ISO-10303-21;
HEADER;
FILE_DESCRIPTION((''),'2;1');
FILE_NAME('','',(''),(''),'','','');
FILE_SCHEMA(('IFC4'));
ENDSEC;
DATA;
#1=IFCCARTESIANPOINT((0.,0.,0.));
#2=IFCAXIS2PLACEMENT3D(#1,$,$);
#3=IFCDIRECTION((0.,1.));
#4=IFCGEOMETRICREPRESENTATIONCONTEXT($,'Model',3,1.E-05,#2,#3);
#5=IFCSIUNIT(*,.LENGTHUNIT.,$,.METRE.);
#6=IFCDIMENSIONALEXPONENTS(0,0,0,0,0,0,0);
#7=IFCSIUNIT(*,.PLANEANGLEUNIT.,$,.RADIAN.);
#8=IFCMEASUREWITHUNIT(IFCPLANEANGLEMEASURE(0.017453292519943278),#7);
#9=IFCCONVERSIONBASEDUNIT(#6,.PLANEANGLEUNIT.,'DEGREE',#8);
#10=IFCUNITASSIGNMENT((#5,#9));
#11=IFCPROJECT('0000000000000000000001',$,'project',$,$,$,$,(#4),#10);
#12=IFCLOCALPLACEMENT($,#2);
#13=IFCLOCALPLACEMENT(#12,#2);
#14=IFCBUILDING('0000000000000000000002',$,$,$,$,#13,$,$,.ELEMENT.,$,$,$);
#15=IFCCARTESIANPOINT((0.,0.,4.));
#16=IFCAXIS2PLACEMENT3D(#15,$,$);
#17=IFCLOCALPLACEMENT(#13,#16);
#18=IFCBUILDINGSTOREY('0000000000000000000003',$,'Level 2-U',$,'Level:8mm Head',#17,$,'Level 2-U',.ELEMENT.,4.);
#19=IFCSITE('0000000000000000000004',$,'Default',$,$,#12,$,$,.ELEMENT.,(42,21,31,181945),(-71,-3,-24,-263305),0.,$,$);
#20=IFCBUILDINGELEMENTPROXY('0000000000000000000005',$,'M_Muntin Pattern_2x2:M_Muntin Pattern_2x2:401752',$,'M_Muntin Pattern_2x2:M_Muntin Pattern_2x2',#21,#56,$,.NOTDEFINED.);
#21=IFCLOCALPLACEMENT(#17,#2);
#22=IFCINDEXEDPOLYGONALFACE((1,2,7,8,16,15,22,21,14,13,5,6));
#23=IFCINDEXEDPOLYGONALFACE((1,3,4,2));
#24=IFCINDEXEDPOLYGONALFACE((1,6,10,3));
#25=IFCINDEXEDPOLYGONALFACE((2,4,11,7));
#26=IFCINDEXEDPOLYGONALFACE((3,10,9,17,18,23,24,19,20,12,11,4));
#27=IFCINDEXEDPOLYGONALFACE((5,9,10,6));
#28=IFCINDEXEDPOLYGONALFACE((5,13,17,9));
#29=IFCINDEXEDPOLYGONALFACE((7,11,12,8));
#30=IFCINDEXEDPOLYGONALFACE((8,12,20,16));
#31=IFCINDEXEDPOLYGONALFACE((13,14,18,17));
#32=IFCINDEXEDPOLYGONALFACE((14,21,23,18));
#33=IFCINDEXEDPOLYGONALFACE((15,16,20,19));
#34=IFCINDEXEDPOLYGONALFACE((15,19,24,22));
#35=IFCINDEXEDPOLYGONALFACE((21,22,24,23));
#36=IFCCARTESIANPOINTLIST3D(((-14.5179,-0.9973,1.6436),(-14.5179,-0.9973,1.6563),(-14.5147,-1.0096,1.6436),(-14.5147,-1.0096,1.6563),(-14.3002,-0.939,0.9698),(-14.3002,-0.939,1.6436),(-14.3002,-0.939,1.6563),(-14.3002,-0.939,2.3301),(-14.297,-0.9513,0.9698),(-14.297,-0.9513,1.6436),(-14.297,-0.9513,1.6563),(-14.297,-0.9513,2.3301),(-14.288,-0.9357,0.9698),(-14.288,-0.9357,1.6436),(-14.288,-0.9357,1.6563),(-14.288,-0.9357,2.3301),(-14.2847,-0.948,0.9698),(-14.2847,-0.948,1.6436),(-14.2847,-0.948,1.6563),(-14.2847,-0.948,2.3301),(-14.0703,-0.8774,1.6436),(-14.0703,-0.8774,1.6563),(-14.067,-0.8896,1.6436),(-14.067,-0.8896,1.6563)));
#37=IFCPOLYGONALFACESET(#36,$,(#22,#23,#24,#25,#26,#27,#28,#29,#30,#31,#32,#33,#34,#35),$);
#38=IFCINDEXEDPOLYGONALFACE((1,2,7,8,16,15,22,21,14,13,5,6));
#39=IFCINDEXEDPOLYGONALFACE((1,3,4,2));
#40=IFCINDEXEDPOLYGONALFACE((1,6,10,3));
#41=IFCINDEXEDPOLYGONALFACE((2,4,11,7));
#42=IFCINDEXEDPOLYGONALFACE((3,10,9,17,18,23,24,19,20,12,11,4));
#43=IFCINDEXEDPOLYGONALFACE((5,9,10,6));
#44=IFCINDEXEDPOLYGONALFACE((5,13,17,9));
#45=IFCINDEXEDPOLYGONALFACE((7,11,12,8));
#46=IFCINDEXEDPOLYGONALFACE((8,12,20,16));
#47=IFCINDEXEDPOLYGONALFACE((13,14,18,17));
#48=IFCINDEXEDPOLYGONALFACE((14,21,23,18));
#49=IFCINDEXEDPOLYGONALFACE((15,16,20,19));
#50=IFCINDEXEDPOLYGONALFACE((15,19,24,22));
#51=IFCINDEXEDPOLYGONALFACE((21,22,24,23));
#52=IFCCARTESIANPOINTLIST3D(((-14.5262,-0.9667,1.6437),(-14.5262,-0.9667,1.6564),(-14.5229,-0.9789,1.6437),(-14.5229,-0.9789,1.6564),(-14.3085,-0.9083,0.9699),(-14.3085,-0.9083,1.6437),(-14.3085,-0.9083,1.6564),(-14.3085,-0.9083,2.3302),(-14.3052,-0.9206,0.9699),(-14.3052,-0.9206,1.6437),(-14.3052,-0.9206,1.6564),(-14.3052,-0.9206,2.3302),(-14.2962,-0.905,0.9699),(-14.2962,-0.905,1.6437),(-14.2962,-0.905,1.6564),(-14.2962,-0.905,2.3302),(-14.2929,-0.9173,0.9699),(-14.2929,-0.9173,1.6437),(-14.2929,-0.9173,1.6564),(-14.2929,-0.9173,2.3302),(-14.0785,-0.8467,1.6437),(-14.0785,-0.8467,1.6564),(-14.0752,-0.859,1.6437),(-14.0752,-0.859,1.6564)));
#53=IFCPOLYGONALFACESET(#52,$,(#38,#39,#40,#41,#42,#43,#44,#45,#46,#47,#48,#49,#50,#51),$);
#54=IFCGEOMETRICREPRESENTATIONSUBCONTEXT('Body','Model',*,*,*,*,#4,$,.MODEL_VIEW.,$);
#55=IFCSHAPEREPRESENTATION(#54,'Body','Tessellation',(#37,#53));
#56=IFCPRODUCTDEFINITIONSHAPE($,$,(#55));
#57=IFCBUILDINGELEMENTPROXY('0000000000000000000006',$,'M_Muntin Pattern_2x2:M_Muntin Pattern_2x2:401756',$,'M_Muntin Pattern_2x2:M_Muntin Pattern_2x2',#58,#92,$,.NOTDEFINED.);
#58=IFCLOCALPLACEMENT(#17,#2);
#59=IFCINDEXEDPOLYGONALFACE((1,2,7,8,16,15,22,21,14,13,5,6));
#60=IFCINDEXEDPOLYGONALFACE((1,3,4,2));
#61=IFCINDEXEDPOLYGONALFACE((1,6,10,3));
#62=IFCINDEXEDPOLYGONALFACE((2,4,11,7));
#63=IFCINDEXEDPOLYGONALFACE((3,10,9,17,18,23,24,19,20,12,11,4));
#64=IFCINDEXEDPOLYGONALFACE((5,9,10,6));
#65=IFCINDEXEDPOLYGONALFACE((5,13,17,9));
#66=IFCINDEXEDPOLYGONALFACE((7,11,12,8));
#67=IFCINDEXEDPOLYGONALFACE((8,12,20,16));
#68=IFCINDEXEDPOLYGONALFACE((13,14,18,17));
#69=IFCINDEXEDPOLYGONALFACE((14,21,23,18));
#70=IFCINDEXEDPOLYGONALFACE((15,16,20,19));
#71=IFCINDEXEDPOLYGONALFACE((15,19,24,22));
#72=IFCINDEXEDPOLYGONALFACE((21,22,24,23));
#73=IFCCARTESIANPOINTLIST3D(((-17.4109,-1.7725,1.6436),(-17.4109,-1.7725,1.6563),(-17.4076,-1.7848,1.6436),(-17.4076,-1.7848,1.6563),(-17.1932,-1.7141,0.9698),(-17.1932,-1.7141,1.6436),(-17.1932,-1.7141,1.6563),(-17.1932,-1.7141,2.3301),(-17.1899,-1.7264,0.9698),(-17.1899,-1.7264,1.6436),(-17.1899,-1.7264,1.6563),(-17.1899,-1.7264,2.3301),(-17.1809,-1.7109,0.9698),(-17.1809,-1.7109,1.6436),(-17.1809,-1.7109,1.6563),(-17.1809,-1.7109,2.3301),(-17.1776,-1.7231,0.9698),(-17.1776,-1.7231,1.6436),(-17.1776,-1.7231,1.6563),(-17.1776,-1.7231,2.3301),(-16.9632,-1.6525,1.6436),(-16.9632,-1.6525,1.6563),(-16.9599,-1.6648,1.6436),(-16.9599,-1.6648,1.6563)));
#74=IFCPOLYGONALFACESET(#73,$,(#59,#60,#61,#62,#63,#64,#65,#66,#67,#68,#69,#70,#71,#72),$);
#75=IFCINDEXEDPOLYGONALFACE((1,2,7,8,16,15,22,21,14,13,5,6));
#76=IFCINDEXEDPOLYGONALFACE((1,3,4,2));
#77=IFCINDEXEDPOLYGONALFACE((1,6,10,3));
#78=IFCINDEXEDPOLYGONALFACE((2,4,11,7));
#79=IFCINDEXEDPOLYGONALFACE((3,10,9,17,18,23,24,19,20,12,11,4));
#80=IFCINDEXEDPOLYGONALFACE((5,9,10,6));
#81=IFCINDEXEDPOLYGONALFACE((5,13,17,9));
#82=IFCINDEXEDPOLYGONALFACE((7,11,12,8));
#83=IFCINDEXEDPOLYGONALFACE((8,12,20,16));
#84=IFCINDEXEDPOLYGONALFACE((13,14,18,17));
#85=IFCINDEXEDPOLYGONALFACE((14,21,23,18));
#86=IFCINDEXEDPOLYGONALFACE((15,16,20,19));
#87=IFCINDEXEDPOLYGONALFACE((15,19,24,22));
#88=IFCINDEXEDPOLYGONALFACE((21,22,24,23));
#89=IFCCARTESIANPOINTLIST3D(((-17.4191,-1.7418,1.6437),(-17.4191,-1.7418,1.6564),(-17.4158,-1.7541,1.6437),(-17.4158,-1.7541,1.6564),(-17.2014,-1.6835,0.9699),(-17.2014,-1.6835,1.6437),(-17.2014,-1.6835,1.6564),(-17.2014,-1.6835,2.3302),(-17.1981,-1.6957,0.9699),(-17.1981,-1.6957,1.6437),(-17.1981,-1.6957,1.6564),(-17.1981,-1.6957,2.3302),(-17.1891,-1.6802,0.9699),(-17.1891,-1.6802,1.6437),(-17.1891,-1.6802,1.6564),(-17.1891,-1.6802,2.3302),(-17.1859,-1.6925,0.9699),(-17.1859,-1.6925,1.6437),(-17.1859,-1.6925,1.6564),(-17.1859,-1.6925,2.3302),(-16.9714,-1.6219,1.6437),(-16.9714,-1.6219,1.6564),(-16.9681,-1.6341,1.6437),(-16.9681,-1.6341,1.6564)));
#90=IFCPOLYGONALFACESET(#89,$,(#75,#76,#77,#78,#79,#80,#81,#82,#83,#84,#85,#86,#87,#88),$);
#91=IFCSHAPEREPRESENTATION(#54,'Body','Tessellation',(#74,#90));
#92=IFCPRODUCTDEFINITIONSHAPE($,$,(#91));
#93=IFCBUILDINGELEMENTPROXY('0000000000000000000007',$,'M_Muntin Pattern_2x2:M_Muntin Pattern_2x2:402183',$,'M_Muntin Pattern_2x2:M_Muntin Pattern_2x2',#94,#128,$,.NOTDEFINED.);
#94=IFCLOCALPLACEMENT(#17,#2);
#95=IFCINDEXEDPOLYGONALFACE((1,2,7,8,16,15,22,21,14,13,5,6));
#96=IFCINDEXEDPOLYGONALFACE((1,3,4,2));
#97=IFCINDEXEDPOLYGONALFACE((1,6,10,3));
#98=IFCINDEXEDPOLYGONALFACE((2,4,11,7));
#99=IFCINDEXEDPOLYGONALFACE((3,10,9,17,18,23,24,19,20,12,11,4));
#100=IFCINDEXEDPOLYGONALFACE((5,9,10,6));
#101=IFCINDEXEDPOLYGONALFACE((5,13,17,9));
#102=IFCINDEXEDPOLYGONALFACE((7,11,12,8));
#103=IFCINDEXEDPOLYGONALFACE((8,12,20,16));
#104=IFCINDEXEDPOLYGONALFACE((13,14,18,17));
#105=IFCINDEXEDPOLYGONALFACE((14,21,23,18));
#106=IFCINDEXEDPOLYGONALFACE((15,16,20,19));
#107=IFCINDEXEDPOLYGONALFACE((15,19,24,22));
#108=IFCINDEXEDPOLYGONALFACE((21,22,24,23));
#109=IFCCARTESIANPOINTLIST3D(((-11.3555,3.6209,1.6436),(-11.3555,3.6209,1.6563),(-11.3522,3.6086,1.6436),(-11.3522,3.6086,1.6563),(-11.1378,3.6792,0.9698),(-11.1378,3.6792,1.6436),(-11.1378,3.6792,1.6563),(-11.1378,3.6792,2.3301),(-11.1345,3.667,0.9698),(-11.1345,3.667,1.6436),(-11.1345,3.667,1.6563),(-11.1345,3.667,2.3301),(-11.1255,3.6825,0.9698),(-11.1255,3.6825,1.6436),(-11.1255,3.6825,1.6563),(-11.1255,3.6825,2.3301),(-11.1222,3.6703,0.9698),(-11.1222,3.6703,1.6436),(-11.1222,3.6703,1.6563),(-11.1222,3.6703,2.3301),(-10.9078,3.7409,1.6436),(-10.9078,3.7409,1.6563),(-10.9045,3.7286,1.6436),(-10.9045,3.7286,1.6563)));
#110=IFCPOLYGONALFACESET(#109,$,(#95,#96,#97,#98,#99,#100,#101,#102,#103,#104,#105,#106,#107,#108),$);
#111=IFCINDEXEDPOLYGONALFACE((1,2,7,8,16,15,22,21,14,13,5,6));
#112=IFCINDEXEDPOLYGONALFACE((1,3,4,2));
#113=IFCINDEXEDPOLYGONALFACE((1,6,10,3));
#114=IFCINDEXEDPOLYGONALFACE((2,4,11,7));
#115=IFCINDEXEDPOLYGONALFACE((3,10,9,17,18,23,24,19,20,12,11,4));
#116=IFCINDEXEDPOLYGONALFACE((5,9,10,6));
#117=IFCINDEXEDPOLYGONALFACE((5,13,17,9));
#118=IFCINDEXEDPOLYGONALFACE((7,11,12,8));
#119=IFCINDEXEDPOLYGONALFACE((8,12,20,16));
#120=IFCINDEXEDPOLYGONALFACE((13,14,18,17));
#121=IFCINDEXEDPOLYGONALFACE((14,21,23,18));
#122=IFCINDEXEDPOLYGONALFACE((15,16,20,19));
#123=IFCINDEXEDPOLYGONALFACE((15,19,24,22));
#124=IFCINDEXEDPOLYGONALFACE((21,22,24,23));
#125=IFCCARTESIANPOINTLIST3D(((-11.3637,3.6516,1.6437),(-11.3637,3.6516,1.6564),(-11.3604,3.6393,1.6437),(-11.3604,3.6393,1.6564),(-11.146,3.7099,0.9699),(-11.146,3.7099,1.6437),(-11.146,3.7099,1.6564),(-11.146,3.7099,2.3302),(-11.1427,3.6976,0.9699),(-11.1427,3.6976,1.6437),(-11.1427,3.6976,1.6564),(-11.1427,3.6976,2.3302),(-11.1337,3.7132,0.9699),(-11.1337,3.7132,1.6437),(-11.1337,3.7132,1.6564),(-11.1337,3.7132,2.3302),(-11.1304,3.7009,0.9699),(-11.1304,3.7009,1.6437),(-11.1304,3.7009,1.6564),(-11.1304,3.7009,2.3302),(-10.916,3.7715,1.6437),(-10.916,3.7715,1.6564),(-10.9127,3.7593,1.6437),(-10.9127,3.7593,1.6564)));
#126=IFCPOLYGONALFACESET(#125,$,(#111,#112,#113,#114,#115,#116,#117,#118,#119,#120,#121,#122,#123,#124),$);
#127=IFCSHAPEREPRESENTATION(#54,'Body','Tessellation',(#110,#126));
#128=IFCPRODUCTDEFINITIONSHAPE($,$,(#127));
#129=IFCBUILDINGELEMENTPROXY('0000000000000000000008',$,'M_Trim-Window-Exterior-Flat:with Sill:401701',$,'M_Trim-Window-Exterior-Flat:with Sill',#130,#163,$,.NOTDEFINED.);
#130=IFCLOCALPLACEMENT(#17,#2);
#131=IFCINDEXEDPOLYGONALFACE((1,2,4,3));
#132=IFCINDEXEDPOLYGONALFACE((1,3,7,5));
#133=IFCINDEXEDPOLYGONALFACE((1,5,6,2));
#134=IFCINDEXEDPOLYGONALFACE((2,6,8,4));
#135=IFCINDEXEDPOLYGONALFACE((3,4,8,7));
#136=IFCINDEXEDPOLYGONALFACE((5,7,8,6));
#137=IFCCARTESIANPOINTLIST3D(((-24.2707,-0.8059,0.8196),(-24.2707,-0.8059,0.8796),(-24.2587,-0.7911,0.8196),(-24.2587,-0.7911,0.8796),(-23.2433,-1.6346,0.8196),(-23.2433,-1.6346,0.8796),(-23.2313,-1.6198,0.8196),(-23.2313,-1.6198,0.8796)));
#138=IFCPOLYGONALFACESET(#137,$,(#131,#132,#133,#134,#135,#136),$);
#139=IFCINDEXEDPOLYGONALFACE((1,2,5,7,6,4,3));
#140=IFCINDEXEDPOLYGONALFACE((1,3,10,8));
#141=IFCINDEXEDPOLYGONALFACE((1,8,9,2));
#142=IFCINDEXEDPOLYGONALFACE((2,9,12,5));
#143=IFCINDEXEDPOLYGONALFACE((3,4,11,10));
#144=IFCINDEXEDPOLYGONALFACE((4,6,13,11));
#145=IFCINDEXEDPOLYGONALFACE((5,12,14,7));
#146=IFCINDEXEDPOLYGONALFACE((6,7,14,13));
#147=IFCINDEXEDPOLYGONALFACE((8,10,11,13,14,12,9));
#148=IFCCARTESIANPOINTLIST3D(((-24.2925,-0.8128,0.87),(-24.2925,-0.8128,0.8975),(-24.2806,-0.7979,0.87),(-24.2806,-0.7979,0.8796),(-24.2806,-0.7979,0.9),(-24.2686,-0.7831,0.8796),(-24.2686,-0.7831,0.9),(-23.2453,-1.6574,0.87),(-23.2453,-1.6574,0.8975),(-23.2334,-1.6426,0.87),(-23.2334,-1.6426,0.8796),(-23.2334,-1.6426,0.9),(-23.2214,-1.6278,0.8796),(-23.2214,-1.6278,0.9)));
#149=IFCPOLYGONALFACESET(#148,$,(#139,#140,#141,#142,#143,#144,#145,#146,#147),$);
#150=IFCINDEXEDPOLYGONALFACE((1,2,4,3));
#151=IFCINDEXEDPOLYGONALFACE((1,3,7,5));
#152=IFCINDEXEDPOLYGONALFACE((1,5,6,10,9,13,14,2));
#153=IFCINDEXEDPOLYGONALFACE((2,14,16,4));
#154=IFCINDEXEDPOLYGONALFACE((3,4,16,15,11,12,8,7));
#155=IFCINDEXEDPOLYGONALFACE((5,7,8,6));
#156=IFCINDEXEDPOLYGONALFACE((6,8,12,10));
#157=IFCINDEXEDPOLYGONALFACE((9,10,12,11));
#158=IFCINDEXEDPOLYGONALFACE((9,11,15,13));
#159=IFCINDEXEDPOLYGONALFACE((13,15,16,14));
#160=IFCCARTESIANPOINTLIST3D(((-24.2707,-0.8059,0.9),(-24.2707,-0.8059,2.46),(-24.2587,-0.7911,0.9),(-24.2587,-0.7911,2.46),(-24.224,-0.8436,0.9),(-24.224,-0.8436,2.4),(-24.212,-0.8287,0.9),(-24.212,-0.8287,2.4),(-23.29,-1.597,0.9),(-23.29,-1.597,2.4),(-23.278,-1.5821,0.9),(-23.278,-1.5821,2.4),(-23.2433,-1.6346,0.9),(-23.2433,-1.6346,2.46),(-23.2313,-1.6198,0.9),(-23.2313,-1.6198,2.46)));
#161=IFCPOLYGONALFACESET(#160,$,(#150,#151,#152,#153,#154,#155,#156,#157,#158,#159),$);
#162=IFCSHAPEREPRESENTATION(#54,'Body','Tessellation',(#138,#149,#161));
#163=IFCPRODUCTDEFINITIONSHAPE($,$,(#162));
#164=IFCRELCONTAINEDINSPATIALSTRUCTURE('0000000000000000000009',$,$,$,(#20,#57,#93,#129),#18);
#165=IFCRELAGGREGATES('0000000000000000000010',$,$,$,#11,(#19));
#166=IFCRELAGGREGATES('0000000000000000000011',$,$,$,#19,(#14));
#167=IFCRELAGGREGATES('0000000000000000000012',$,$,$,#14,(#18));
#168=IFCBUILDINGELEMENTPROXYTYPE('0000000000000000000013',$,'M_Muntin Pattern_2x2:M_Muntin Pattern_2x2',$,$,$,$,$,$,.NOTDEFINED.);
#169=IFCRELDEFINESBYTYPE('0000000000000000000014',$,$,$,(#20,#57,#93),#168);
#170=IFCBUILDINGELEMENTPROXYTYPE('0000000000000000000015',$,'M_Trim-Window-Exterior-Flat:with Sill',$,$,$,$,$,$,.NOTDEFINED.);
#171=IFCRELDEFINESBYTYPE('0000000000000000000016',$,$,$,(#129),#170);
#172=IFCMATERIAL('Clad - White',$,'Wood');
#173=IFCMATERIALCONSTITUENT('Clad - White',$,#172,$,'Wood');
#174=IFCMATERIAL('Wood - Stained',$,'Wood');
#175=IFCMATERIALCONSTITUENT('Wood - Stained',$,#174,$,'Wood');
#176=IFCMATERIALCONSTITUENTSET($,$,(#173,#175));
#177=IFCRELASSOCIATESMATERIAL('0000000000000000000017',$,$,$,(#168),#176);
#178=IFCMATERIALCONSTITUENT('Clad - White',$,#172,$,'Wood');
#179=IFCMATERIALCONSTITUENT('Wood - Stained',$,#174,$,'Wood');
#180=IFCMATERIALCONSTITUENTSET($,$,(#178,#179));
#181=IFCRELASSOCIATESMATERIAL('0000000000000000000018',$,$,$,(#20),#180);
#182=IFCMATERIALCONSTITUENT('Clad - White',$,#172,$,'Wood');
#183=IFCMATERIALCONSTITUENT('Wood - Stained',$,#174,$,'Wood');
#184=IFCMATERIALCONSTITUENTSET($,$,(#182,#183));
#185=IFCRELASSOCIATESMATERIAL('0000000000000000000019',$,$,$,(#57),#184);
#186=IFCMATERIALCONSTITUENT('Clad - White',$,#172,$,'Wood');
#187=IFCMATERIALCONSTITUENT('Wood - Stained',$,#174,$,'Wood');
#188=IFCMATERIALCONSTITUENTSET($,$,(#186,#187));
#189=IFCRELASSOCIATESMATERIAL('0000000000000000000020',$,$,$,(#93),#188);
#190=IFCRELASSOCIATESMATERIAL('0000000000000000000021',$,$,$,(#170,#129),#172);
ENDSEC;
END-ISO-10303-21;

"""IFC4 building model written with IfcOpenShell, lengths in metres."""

from ifc_helpers import new_model, entity, si_unit, converted_unit, direction, frame, frame_2d, origin, place, context, subcontext, project, spatial, polyline, rectangle, outline, extrude, source, transform, mapped, material, constituent, constituent_set, type_object, type_shapes, element, save


model = new_model("IFC4")

# Units and contexts
model_context = context("Model", 3, precision=1e-05, world=origin(), true_north=direction((0.0, 1.0)))
body_context = subcontext(model_context, "Body", "Model", "MODEL_VIEW")
ifc_project = project(units=[si_unit("LENGTHUNIT", "METRE"), converted_unit("PLANEANGLEUNIT", "DEGREE", entity("IfcPlaneAngleMeasure", 0.017453292519943278), si_unit("PLANEANGLEUNIT", "RADIAN"), dimensions=[0, 0, 0, 0, 0, 0, 0])], contexts=[model_context])

# Site, building, storey
site_placement = place(None, origin())
site = spatial("IfcSite", under=ifc_project, at=site_placement, Name="Default", CompositionType="ELEMENT", RefLatitude=(42, 21, 31, 181945), RefLongitude=(-71, -3, -24, -263305), RefElevation=0.0)
building_placement = place(site_placement, origin())
building = spatial("IfcBuilding", under=site, at=building_placement, CompositionType="ELEMENT")
storey_placement = place(building_placement, frame((0.0, 0.0, 4.0)))
storey = spatial("IfcBuildingStorey", under=building, at=storey_placement, Name="Level 2-U", ObjectType="Level:8mm Head", LongName="Level 2-U", CompositionType="ELEMENT", Elevation=4.0)

# Building element proxies
ifc_material_1 = material(Name="Clad - White", Category="Wood")
ifc_material_2 = material(Name="Wood - Stained", Category="Wood")
ifc_constituent_1 = constituent(ifc_material_1, Name="Clad - White", Category="Wood")
ifc_constituent_2 = constituent(ifc_material_2, Name="Wood - Stained", Category="Wood")
ifc_constituent_set_1 = constituent_set(constituents=[ifc_constituent_1, ifc_constituent_2])
building_element_proxy_type_1 = type_object("IfcBuildingElementProxyType", Name="M_Muntin Pattern_2x2:M_Muntin Pattern_2x2", PredefinedType="NOTDEFINED", material=ifc_constituent_set_1)
shared_shape_1 = source(origin(), body_context, "Body", "SweptSolid", [
    extrude(outline(polyline([(0.0064, -0.0064), (0.6801, -0.0064), (0.6801, 0.0063), (0.0064, 0.0063), (0.0064, 0.2317), (-0.0063, 0.2317), (-0.0063, 0.0063), (-0.6802, 0.0063), (-0.6802, -0.0064), (-0.0063, -0.0064), (-0.0063, -0.2317), (0.0064, -0.2317), (0.0064, -0.0064)])), frame((0.0, -0.0222, 0.6801), z_axis=(0.0, 1.0, 0.0), x_axis=(0.0, 0.0, 1.0)), (0.0, 0.0, 1.0), 0.0127),
    extrude(outline(polyline([(0.0064, -0.0064), (0.6802, -0.0064), (0.6802, 0.0063), (0.0064, 0.0063), (0.0064, 0.2317), (-0.0063, 0.2317), (-0.0063, 0.0063), (-0.6802, 0.0063), (-0.6802, -0.0064), (-0.0063, -0.0064), (-0.0063, -0.2317), (0.0064, -0.2317), (0.0064, -0.0064)])), frame((0.0, 0.0095, 0.6802), z_axis=(0.0, 1.0, 0.0), x_axis=(0.0, 0.0, 1.0)), (0.0, 0.0, 1.0), 0.0127),
])
type_shapes(building_element_proxy_type_1, [shared_shape_1])
ifc_constituent_3 = constituent(ifc_material_1, Name="Clad - White", Category="Wood")
ifc_constituent_4 = constituent(ifc_material_2, Name="Wood - Stained", Category="Wood")
ifc_constituent_set_2 = constituent_set(constituents=[ifc_constituent_3, ifc_constituent_4])
proxy_1_placement = place(storey_placement, frame((-14.2966, -0.9281, 0.9699), z_axis=(0.0, 0.0, 1.0), x_axis=(0.965926, 0.258819, 0.0)))
element("IfcBuildingElementProxy", 1, at=proxy_1_placement, inside=storey, type_object=building_element_proxy_type_1, material=ifc_constituent_set_2, Name="M_Muntin Pattern_2x2:M_Muntin Pattern_2x2:401752", ObjectType="M_Muntin Pattern_2x2:M_Muntin Pattern_2x2", PredefinedType="NOTDEFINED", context=body_context, shape_type="MappedRepresentation", body=[
    mapped(shared_shape_1, transform((0.0, 0.0, 0.0), scale=1.0)),
])
ifc_constituent_5 = constituent(ifc_material_1, Name="Clad - White", Category="Wood")
ifc_constituent_6 = constituent(ifc_material_2, Name="Wood - Stained", Category="Wood")
ifc_constituent_set_3 = constituent_set(constituents=[ifc_constituent_5, ifc_constituent_6])
proxy_2_placement = place(storey_placement, frame((-17.1895, -1.7033, 0.9699), z_axis=(0.0, 0.0, 1.0), x_axis=(0.965926, 0.258819, 0.0)))
element("IfcBuildingElementProxy", 2, at=proxy_2_placement, inside=storey, type_object=building_element_proxy_type_1, material=ifc_constituent_set_3, Name="M_Muntin Pattern_2x2:M_Muntin Pattern_2x2:401756", ObjectType="M_Muntin Pattern_2x2:M_Muntin Pattern_2x2", PredefinedType="NOTDEFINED", context=body_context, shape_type="MappedRepresentation", body=[
    mapped(shared_shape_1, transform((0.0, 0.0, 0.0), scale=1.0)),
])
ifc_constituent_7 = constituent(ifc_material_1, Name="Clad - White", Category="Wood")
ifc_constituent_8 = constituent(ifc_material_2, Name="Wood - Stained", Category="Wood")
ifc_constituent_set_4 = constituent_set(constituents=[ifc_constituent_7, ifc_constituent_8])
proxy_3_placement = place(storey_placement, frame((-11.1341, 3.6901, 0.9699), z_axis=(0.0, 0.0, 1.0), x_axis=(0.965926, 0.258819, 0.0)))
element("IfcBuildingElementProxy", 3, at=proxy_3_placement, inside=storey, type_object=building_element_proxy_type_1, material=ifc_constituent_set_4, Name="M_Muntin Pattern_2x2:M_Muntin Pattern_2x2:402183", ObjectType="M_Muntin Pattern_2x2:M_Muntin Pattern_2x2", PredefinedType="NOTDEFINED", context=body_context, shape_type="MappedRepresentation", body=[
    mapped(shared_shape_1, transform((0.0, 0.0, 0.0), scale=1.0)),
])
building_element_proxy_type_2 = type_object("IfcBuildingElementProxyType", Name="M_Trim-Window-Exterior-Flat:with Sill", PredefinedType="NOTDEFINED", material=ifc_material_1)
shared_shape_2 = source(origin(), body_context, "Body", "SweptSolid", [
    extrude(rectangle(XDim=1.32, YDim=0.06, at=frame_2d((0.0, 0.0), x_axis=(1.0, 0.0))), frame((0.0, -1.5504, 0.0), z_axis=(0.0, 0.0, 1.0), x_axis=(-1.0, 0.0, 0.0)), (0.0, 0.0, 1.0), 0.019),
    extrude(outline(polyline([(-0.019, -0.0152), (0.0, -0.0152), (0.0, -0.0057), (0.019, -0.0057), (0.019, 0.0148), (0.0, 0.0148), (-0.019, 0.0123), (-0.019, -0.0152)])), frame((-0.6727, -1.5148, 0.019), z_axis=(1.0, 0.0, 0.0), x_axis=(0.0, 0.0, -1.0)), (0.0, 0.0, 1.0), 1.3454),
    extrude(outline(polyline([(-0.795, -0.66), (0.765, -0.66), (0.765, -0.6), (-0.735, -0.6), (-0.735, 0.6), (0.765, 0.6), (0.765, 0.66), (-0.795, 0.66), (-0.795, -0.66)])), frame((0.0, -0.735, 0.0), z_axis=(0.0, 0.0, 1.0), x_axis=(0.0, -1.0, 0.0)), (0.0, 0.0, 1.0), 0.019),
])
type_shapes(building_element_proxy_type_2, [shared_shape_2])
for number, where, z_axis, x_axis, name in (
    (4, (-23.745, -1.2054, 2.4), (-0.62782, -0.778359, 0.0), (0.778359, -0.62782, 0.0), "M_Trim-Window-Exterior-Flat:with Sill:401701"),
):
    element("IfcBuildingElementProxy", number, at=place(storey_placement, frame(where, z_axis=z_axis, x_axis=x_axis)), inside=storey, type_object=building_element_proxy_type_2, material=ifc_material_1, Name=name, ObjectType="M_Trim-Window-Exterior-Flat:with Sill", PredefinedType="NOTDEFINED", context=body_context, shape_type="MappedRepresentation", body=[
        mapped(shared_shape_2, transform((0.0, 0.0, 0.0), scale=1.0)),
    ])

save(model, "model.ifc")
